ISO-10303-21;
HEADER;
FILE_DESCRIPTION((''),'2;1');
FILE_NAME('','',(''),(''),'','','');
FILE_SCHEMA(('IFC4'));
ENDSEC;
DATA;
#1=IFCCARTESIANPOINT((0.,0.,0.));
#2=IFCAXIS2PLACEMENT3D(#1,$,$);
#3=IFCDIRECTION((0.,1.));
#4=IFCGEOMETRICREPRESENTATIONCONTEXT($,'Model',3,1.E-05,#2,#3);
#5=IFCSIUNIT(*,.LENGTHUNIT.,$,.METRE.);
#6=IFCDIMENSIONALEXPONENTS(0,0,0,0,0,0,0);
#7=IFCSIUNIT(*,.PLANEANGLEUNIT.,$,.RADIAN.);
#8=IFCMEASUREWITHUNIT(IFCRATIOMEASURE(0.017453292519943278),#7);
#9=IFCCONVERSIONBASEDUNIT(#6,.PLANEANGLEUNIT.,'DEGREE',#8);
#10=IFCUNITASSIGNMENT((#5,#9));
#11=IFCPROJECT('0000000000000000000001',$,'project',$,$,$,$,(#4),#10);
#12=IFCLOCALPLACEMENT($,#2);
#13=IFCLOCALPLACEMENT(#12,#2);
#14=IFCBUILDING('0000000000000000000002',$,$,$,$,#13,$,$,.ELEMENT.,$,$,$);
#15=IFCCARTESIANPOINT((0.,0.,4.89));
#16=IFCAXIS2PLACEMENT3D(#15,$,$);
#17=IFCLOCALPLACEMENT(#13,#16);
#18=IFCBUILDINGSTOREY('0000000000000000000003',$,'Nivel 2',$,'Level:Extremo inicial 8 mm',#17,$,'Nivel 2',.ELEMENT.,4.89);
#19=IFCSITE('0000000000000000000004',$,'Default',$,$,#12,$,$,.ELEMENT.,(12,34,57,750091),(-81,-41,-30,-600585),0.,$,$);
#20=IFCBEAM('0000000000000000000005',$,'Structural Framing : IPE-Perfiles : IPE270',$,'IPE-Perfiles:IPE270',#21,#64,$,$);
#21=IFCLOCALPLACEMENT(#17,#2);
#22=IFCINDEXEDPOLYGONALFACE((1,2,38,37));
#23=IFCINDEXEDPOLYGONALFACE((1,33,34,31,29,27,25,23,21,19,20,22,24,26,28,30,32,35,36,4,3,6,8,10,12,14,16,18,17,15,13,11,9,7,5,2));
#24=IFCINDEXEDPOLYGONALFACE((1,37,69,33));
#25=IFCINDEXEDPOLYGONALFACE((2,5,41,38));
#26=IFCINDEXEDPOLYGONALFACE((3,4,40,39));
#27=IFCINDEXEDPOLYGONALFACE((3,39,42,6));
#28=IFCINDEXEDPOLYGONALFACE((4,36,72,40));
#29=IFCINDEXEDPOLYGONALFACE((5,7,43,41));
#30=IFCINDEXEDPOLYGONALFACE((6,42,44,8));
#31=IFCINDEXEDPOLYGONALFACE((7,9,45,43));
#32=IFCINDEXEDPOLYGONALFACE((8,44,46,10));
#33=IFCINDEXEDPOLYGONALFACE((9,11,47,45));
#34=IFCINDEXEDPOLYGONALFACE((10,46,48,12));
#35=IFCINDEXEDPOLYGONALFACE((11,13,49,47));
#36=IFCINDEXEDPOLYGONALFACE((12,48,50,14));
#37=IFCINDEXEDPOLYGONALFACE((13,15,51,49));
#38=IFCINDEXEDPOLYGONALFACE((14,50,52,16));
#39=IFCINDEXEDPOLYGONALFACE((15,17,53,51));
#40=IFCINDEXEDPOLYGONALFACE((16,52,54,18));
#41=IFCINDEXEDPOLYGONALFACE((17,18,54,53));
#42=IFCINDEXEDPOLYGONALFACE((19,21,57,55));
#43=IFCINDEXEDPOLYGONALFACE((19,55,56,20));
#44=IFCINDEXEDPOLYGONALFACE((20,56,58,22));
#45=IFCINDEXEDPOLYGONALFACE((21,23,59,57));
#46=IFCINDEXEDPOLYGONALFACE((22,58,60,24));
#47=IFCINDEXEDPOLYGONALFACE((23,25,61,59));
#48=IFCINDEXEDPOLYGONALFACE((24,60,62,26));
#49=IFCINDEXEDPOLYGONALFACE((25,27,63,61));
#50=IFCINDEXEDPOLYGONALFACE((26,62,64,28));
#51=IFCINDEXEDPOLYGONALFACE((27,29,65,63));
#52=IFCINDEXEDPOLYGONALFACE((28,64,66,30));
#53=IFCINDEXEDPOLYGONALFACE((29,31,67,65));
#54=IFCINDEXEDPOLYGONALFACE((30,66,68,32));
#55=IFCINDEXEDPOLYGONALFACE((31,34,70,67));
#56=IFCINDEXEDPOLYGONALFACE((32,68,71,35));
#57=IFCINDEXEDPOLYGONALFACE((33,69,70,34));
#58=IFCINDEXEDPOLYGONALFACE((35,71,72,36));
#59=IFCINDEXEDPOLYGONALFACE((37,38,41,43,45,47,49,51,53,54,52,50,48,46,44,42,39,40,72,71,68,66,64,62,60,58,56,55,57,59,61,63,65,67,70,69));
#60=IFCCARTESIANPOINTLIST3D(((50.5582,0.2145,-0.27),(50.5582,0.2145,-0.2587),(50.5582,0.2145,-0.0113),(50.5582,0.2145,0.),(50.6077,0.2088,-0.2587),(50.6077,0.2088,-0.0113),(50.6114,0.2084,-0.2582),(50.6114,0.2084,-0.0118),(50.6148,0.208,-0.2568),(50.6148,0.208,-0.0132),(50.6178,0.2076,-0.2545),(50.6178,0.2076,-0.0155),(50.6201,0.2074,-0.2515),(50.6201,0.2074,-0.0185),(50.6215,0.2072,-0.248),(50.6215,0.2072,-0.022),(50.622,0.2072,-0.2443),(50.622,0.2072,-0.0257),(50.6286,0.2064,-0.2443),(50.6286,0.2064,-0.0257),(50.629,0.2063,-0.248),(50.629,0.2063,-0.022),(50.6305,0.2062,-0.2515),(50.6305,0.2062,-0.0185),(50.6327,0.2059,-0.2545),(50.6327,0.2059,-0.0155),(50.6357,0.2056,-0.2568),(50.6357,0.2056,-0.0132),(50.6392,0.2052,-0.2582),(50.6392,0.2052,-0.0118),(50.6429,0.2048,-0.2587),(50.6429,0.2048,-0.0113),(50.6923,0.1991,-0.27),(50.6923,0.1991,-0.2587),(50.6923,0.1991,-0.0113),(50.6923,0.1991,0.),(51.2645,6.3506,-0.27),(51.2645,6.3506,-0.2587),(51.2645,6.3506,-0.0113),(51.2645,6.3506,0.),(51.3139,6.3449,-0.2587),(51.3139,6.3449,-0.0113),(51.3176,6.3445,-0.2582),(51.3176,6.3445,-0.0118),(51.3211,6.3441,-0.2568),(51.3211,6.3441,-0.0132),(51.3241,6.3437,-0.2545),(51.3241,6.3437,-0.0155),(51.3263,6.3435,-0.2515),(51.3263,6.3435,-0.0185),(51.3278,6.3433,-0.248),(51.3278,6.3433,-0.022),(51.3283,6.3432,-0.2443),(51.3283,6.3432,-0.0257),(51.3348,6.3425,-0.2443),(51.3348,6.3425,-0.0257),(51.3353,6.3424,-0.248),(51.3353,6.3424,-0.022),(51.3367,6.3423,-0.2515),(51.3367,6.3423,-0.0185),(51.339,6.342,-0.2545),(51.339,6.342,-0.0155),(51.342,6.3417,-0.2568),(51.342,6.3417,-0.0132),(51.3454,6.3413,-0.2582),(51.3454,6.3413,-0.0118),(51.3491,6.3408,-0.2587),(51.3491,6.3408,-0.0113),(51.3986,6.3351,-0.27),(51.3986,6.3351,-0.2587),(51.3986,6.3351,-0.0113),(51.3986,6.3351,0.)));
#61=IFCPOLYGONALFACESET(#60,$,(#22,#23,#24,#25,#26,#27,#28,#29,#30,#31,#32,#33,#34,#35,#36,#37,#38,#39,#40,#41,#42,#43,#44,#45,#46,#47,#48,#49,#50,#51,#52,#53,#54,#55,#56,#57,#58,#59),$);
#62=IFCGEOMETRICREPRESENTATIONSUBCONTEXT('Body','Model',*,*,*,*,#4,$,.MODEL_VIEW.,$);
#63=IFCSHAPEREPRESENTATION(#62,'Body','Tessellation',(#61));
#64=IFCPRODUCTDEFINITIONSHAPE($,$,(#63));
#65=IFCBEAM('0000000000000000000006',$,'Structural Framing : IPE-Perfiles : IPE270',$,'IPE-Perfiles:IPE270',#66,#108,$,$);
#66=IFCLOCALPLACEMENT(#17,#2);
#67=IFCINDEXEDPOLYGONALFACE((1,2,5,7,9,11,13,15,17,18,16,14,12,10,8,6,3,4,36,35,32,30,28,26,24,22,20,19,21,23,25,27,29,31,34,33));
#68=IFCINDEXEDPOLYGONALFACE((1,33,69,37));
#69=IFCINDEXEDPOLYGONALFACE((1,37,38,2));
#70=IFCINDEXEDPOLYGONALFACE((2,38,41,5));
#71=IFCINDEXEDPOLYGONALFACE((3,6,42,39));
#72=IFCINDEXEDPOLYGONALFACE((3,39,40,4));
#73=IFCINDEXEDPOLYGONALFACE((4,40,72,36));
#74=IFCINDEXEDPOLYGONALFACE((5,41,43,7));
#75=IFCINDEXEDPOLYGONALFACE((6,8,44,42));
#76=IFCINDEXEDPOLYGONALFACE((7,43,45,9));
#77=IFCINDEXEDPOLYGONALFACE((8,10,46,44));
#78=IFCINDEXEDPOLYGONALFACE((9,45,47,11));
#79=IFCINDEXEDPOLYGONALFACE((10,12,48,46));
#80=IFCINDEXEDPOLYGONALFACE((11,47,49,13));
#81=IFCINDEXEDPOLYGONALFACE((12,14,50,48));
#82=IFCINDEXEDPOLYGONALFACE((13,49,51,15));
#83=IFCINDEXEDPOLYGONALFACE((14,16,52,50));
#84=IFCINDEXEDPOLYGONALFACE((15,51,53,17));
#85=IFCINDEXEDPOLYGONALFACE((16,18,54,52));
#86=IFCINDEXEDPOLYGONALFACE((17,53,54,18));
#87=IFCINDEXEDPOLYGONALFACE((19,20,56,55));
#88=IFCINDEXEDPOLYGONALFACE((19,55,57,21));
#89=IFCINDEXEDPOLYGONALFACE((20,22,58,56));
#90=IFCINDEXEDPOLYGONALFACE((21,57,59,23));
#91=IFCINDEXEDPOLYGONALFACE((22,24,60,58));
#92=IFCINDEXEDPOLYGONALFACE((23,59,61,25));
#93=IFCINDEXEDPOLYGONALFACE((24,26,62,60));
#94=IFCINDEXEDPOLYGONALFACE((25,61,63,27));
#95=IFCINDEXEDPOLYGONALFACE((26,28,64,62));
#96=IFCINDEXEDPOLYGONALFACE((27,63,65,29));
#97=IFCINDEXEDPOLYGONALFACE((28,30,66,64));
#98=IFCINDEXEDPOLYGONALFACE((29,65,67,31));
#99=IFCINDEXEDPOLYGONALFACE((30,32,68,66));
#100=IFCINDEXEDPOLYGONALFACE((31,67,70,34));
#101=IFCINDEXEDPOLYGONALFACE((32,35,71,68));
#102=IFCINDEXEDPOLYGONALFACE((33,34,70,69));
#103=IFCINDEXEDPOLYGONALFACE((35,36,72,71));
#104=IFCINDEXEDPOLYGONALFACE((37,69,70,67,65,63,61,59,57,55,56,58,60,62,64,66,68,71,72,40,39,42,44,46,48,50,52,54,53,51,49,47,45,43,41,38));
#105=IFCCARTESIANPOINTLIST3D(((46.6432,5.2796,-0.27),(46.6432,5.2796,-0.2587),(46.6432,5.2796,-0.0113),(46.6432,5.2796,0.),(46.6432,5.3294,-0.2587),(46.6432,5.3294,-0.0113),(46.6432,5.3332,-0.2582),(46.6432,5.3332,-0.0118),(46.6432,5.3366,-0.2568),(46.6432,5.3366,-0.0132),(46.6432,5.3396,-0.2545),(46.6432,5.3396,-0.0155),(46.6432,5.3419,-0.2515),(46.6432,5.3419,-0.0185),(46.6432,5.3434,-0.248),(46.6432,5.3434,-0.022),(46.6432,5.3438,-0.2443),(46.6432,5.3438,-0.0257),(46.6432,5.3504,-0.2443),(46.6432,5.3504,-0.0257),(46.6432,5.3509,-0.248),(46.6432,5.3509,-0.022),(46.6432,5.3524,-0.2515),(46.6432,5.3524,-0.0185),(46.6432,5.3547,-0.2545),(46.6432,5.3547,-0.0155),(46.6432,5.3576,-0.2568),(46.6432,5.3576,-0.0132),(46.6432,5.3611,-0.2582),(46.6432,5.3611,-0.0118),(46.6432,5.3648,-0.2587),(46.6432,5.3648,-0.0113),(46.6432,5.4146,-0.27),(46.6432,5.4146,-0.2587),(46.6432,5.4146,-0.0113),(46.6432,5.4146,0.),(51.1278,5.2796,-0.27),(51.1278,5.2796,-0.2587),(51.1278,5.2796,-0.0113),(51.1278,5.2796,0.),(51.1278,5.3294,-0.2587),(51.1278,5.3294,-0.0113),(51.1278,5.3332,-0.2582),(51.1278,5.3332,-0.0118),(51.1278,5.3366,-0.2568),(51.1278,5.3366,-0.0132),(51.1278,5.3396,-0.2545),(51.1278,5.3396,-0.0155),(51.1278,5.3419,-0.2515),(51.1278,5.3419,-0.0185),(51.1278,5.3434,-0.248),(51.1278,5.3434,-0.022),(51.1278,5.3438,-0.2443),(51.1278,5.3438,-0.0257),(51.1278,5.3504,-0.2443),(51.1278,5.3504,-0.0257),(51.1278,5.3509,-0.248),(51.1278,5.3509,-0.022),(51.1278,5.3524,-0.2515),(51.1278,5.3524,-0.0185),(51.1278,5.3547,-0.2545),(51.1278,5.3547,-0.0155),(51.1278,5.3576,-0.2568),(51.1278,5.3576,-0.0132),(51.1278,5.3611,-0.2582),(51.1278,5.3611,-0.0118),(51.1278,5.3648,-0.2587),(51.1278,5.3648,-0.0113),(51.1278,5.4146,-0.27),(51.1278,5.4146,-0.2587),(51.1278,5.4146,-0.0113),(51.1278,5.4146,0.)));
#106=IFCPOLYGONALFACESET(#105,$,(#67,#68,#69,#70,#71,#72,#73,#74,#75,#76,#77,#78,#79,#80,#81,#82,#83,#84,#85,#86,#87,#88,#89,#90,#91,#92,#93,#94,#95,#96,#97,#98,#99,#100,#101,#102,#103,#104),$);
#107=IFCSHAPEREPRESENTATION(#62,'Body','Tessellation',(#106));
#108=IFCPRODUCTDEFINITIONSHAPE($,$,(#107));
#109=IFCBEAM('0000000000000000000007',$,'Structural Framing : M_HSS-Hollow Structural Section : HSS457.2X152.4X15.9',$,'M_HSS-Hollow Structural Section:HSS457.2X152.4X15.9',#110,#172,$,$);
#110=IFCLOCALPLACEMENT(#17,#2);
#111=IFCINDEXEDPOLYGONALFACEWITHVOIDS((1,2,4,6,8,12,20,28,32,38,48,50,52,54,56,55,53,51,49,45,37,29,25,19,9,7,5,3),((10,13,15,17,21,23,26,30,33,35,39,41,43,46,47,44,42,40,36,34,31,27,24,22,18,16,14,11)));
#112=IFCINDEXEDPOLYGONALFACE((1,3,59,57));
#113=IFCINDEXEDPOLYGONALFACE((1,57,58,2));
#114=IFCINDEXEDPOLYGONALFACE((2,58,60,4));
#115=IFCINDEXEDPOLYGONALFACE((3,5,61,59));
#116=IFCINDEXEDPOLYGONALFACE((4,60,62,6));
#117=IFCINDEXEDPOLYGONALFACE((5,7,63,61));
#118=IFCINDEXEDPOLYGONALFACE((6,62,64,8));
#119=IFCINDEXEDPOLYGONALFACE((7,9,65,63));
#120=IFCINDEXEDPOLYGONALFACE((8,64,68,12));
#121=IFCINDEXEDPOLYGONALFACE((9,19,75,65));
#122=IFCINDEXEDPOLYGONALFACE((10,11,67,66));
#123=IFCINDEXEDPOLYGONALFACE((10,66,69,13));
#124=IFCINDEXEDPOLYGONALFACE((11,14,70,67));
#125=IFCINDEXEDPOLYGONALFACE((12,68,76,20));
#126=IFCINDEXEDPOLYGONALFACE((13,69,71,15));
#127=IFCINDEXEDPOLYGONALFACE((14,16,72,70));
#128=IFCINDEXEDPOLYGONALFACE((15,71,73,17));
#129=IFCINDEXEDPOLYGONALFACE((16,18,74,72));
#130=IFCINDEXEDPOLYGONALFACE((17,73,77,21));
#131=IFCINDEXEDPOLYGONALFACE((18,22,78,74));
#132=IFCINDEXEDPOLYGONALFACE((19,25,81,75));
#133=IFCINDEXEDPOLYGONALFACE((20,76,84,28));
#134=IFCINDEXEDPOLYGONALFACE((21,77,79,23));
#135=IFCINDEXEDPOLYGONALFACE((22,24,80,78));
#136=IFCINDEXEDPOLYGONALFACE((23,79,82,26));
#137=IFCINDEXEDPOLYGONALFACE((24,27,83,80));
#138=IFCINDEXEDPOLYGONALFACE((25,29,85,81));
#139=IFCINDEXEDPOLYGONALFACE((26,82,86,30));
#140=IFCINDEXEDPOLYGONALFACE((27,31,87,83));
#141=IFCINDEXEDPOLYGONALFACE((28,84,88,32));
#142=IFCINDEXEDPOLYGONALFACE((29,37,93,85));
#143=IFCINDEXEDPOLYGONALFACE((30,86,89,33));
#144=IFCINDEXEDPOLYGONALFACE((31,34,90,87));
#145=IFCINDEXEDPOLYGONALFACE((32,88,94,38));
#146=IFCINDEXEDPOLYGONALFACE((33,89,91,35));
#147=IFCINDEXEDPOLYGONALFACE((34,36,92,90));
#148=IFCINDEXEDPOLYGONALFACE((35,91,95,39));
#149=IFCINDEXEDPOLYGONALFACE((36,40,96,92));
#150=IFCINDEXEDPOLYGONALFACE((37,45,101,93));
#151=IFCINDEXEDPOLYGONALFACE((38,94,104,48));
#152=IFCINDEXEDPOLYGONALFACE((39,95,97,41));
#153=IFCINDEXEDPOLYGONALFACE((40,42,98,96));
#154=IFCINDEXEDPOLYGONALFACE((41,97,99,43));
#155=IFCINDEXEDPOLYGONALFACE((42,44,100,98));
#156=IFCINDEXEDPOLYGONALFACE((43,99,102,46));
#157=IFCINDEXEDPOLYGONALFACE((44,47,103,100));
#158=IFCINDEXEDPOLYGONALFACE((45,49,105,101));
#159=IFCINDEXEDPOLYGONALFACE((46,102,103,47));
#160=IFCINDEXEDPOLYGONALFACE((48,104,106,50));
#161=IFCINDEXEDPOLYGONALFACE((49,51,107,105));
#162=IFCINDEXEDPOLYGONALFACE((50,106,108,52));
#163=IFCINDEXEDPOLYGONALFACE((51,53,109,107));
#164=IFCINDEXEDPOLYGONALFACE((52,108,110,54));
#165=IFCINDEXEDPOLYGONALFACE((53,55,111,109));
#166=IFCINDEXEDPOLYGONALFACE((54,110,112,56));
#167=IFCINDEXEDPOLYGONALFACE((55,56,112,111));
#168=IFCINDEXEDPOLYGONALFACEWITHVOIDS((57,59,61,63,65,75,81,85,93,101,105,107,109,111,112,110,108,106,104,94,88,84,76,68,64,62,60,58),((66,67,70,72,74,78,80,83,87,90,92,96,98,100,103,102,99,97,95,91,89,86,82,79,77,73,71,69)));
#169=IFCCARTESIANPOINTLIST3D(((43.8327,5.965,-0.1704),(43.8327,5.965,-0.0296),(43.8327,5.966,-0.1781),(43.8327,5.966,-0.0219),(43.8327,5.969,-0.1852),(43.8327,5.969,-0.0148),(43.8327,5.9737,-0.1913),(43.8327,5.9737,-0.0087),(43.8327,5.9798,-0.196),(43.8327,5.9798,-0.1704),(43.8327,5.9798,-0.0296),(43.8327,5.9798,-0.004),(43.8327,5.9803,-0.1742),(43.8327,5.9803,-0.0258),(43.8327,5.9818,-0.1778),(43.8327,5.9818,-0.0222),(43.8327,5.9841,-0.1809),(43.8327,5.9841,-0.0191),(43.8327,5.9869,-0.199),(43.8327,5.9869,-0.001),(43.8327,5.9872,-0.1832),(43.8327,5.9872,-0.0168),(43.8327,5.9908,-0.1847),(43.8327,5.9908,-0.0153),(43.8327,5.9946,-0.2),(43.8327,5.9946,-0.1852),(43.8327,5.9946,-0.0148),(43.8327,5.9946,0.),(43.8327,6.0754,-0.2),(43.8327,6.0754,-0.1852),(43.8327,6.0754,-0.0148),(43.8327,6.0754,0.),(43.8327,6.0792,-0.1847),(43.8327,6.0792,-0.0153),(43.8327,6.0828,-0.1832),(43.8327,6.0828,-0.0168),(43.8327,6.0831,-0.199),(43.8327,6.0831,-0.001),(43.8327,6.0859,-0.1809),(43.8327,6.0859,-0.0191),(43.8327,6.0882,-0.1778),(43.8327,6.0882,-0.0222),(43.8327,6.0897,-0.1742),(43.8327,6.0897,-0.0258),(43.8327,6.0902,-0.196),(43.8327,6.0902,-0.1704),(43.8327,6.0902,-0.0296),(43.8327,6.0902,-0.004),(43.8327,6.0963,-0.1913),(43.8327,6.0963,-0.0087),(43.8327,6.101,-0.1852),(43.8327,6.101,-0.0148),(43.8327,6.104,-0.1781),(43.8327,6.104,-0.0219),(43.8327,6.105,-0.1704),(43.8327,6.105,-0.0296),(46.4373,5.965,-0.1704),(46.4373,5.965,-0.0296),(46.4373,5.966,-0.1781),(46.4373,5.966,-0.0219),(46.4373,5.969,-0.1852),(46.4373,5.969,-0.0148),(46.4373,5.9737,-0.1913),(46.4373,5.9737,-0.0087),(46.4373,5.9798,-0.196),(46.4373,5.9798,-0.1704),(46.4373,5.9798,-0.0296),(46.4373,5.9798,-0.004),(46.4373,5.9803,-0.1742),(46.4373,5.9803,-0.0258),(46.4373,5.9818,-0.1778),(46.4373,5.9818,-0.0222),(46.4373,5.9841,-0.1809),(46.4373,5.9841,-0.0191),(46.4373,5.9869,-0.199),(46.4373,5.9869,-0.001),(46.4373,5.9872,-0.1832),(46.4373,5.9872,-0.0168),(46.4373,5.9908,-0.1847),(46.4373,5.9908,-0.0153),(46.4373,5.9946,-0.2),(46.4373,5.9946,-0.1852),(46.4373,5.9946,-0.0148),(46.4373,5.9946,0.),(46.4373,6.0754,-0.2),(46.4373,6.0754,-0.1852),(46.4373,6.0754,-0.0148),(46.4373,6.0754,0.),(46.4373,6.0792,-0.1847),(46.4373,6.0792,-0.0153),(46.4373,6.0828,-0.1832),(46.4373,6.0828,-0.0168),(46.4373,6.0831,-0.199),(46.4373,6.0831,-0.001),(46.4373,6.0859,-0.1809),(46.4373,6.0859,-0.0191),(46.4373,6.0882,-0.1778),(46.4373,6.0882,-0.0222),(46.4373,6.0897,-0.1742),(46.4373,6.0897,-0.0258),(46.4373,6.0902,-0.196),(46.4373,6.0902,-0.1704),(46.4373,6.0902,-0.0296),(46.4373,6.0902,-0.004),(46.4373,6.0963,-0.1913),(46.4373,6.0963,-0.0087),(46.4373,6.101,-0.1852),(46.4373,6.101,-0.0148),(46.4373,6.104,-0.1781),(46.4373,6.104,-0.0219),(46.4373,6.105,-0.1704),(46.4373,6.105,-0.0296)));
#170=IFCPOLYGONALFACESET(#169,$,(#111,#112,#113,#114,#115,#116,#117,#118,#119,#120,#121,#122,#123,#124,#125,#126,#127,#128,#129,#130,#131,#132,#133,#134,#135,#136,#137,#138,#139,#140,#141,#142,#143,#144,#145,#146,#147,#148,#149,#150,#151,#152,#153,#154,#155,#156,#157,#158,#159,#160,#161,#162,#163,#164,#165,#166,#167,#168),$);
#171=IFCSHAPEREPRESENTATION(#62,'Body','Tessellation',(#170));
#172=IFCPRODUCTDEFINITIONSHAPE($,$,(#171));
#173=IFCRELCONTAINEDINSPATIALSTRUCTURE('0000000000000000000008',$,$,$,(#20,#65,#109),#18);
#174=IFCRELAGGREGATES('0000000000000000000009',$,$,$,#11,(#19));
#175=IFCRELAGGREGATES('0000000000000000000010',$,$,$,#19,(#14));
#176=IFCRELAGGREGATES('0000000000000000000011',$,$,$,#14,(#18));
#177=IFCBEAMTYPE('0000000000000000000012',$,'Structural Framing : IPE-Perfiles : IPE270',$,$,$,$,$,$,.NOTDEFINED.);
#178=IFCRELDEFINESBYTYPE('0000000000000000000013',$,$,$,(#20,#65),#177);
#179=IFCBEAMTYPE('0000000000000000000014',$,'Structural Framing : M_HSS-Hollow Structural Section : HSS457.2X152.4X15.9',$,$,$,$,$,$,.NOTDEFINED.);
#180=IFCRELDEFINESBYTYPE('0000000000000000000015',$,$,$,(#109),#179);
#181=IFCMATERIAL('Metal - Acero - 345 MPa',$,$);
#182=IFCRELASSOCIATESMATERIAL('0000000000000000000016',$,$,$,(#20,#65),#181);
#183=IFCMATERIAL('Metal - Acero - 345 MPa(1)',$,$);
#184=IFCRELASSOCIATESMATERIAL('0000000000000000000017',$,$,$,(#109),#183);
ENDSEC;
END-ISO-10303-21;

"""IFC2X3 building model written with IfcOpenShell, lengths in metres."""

from ifc_helpers import new_model, entity, si_unit, converted_unit, direction, frame, frame_2d, origin, place, context, subcontext, project, spatial, polyline, circle_curve, parameter, trimmed, segment, composite_curve, i_section, outline, extrude, material, type_object, element, save


model = new_model("IFC2X3")

# Units and contexts
model_context = context("Model", 3, precision=1e-05, world=origin(), true_north=direction((0.0, 1.0)))
body_context = subcontext(model_context, "Body", "Model", "MODEL_VIEW")
ifc_project = project(units=[si_unit("LENGTHUNIT", "METRE"), converted_unit("PLANEANGLEUNIT", "DEGREE", entity("IfcRatioMeasure", 0.017453292519943278), si_unit("PLANEANGLEUNIT", "RADIAN"), dimensions=[0, 0, 0, 0, 0, 0, 0])], contexts=[model_context])

# Site, building, storey
site_placement = place(None, origin())
site = spatial("IfcSite", under=ifc_project, at=site_placement, Name="Default", CompositionType="ELEMENT", RefLatitude=(12, 34, 57, 750091), RefLongitude=(-81, -41, -30, -600585), RefElevation=0.0)
building_placement = place(site_placement, origin())
building = spatial("IfcBuilding", under=site, at=building_placement, CompositionType="ELEMENT")
storey_placement = place(building_placement, frame((0.0, 0.0, 4.89)))
storey = spatial("IfcBuildingStorey", under=building, at=storey_placement, Name="Nivel 2", ObjectType="Level:Extremo inicial 8 mm", LongName="Nivel 2", CompositionType="ELEMENT", Elevation=4.89)

# Shared definitions
ifc_material_1 = material(Name="Metal - Acero - 345 MPa")
ifc_material_2 = material(Name="Metal - Acero - 345 MPa(1)")

# Beams
beam_type_1 = type_object("IfcBeamType", Name="Structural Framing : IPE-Perfiles : IPE270", PredefinedType="NOTDEFINED")
beam_1_placement = place(storey_placement, frame((50.6238, 0.1935, 0.0), z_axis=(0.0, 0.0, 1.0), x_axis=(0.114344, 0.993441, 0.0)))
element("IfcBeam", 1, at=beam_1_placement, inside=storey, type_object=beam_type_1, material=ifc_material_1, Name="Structural Framing : IPE-Perfiles : IPE270", ObjectType="IPE-Perfiles:IPE270", context=body_context, shape_type="SweptSolid", body=[
    extrude(i_section(OverallWidth=0.135, OverallDepth=0.27, WebThickness=0.0066, FlangeThickness=0.0113, FilletRadius=0.0144, at=frame_2d((0.0, 0.0), x_axis=(0.0, 1.0))), frame((0.0133, 0.0, -0.135), z_axis=(1.0, 0.0, 0.0), x_axis=(0.0, 0.0, -1.0)), (0.0, 0.0, 1.0), 6.1766),
])
beam_2_placement = place(storey_placement, frame((46.55, 5.3471, 0.0)))
element("IfcBeam", 2, at=beam_2_placement, inside=storey, type_object=beam_type_1, material=ifc_material_1, Name="Structural Framing : IPE-Perfiles : IPE270", ObjectType="IPE-Perfiles:IPE270", context=body_context, shape_type="SweptSolid", body=[
    extrude(i_section(OverallWidth=0.135, OverallDepth=0.27, WebThickness=0.0066, FlangeThickness=0.0113, FilletRadius=0.0144, at=frame_2d((0.0, 0.0), x_axis=(0.0, 1.0))), frame((0.0932, 0.0, -0.135), z_axis=(1.0, 0.0, 0.0), x_axis=(0.0, 0.0, -1.0)), (0.0, 0.0, 1.0), 4.4846),
])
beam_type_2 = type_object("IfcBeamType", Name="Structural Framing : M_HSS-Hollow Structural Section : HSS457.2X152.4X15.9", PredefinedType="NOTDEFINED")
beam_3_placement = place(storey_placement, frame((43.74, 6.035, 0.0)))
element("IfcBeam", 3, at=beam_3_placement, inside=storey, type_object=beam_type_2, material=ifc_material_2, Name="Structural Framing : M_HSS-Hollow Structural Section : HSS457.2X152.4X15.9", ObjectType="M_HSS-Hollow Structural Section:HSS457.2X152.4X15.9", context=body_context, shape_type="SweptSolid", body=[
    extrude(outline(composite_curve([segment(trimmed(circle_curve(frame_2d((-0.0404, -0.0704), x_axis=(1.0, 0.0)), 0.0296), [parameter(180.0)], [parameter(270.0)], True, "PARAMETER"), True, "CONTINUOUS"), segment(polyline([(-0.0404, -0.1), (0.0404, -0.1)]), True, "CONTINUOUS"), segment(trimmed(circle_curve(frame_2d((0.0404, -0.0704), x_axis=(1.0, 0.0)), 0.0296), [parameter(270.0)], [parameter(0.0)], True, "PARAMETER"), True, "CONTINUOUS"), segment(polyline([(0.07, -0.0704), (0.07, 0.0704)]), True, "CONTINUOUS"), segment(trimmed(circle_curve(frame_2d((0.0404, 0.0704), x_axis=(1.0, 0.0)), 0.0296), [parameter(360.0)], [parameter(90.0)], True, "PARAMETER"), True, "CONTINUOUS"), segment(polyline([(0.0404, 0.1), (-0.0404, 0.1)]), True, "CONTINUOUS"), segment(trimmed(circle_curve(frame_2d((-0.0404, 0.0704), x_axis=(1.0, 0.0)), 0.0296), [parameter(90.0)], [parameter(180.0)], True, "PARAMETER"), True, "CONTINUOUS"), segment(polyline([(-0.07, 0.0704), (-0.07, -0.0704)]), True, "CONTINUOUS")], self_intersect=False), holes=[composite_curve([segment(polyline([(0.0404, -0.0852), (-0.0404, -0.0852)]), True, "CONTINUOUS"), segment(trimmed(circle_curve(frame_2d((-0.0404, -0.0704), x_axis=(1.0, 0.0)), 0.0148), [parameter(180.0)], [parameter(270.0)], True, "PARAMETER"), False, "CONTINUOUS"), segment(polyline([(-0.0552, -0.0704), (-0.0552, 0.0704)]), True, "CONTINUOUS"), segment(trimmed(circle_curve(frame_2d((-0.0404, 0.0704), x_axis=(1.0, 0.0)), 0.0148), [parameter(90.0)], [parameter(180.0)], True, "PARAMETER"), False, "CONTINUOUS"), segment(polyline([(-0.0404, 0.0852), (0.0404, 0.0852)]), True, "CONTINUOUS"), segment(trimmed(circle_curve(frame_2d((0.0404, 0.0704), x_axis=(1.0, 0.0)), 0.0148), [parameter(0.0)], [parameter(90.0)], True, "PARAMETER"), False, "CONTINUOUS"), segment(polyline([(0.0552, 0.0704), (0.0552, -0.0704)]), True, "CONTINUOUS"), segment(trimmed(circle_curve(frame_2d((0.0404, -0.0704), x_axis=(1.0, 0.0)), 0.0148), [parameter(270.0)], [parameter(0.0)], True, "PARAMETER"), False, "CONTINUOUS")], self_intersect=False)]), frame((0.0927, 0.0, -0.1), z_axis=(1.0, 0.0, 0.0), x_axis=(0.0, -1.0, 0.0)), (0.0, 0.0, 1.0), 2.6046),
])

save(model, "model.ifc")
